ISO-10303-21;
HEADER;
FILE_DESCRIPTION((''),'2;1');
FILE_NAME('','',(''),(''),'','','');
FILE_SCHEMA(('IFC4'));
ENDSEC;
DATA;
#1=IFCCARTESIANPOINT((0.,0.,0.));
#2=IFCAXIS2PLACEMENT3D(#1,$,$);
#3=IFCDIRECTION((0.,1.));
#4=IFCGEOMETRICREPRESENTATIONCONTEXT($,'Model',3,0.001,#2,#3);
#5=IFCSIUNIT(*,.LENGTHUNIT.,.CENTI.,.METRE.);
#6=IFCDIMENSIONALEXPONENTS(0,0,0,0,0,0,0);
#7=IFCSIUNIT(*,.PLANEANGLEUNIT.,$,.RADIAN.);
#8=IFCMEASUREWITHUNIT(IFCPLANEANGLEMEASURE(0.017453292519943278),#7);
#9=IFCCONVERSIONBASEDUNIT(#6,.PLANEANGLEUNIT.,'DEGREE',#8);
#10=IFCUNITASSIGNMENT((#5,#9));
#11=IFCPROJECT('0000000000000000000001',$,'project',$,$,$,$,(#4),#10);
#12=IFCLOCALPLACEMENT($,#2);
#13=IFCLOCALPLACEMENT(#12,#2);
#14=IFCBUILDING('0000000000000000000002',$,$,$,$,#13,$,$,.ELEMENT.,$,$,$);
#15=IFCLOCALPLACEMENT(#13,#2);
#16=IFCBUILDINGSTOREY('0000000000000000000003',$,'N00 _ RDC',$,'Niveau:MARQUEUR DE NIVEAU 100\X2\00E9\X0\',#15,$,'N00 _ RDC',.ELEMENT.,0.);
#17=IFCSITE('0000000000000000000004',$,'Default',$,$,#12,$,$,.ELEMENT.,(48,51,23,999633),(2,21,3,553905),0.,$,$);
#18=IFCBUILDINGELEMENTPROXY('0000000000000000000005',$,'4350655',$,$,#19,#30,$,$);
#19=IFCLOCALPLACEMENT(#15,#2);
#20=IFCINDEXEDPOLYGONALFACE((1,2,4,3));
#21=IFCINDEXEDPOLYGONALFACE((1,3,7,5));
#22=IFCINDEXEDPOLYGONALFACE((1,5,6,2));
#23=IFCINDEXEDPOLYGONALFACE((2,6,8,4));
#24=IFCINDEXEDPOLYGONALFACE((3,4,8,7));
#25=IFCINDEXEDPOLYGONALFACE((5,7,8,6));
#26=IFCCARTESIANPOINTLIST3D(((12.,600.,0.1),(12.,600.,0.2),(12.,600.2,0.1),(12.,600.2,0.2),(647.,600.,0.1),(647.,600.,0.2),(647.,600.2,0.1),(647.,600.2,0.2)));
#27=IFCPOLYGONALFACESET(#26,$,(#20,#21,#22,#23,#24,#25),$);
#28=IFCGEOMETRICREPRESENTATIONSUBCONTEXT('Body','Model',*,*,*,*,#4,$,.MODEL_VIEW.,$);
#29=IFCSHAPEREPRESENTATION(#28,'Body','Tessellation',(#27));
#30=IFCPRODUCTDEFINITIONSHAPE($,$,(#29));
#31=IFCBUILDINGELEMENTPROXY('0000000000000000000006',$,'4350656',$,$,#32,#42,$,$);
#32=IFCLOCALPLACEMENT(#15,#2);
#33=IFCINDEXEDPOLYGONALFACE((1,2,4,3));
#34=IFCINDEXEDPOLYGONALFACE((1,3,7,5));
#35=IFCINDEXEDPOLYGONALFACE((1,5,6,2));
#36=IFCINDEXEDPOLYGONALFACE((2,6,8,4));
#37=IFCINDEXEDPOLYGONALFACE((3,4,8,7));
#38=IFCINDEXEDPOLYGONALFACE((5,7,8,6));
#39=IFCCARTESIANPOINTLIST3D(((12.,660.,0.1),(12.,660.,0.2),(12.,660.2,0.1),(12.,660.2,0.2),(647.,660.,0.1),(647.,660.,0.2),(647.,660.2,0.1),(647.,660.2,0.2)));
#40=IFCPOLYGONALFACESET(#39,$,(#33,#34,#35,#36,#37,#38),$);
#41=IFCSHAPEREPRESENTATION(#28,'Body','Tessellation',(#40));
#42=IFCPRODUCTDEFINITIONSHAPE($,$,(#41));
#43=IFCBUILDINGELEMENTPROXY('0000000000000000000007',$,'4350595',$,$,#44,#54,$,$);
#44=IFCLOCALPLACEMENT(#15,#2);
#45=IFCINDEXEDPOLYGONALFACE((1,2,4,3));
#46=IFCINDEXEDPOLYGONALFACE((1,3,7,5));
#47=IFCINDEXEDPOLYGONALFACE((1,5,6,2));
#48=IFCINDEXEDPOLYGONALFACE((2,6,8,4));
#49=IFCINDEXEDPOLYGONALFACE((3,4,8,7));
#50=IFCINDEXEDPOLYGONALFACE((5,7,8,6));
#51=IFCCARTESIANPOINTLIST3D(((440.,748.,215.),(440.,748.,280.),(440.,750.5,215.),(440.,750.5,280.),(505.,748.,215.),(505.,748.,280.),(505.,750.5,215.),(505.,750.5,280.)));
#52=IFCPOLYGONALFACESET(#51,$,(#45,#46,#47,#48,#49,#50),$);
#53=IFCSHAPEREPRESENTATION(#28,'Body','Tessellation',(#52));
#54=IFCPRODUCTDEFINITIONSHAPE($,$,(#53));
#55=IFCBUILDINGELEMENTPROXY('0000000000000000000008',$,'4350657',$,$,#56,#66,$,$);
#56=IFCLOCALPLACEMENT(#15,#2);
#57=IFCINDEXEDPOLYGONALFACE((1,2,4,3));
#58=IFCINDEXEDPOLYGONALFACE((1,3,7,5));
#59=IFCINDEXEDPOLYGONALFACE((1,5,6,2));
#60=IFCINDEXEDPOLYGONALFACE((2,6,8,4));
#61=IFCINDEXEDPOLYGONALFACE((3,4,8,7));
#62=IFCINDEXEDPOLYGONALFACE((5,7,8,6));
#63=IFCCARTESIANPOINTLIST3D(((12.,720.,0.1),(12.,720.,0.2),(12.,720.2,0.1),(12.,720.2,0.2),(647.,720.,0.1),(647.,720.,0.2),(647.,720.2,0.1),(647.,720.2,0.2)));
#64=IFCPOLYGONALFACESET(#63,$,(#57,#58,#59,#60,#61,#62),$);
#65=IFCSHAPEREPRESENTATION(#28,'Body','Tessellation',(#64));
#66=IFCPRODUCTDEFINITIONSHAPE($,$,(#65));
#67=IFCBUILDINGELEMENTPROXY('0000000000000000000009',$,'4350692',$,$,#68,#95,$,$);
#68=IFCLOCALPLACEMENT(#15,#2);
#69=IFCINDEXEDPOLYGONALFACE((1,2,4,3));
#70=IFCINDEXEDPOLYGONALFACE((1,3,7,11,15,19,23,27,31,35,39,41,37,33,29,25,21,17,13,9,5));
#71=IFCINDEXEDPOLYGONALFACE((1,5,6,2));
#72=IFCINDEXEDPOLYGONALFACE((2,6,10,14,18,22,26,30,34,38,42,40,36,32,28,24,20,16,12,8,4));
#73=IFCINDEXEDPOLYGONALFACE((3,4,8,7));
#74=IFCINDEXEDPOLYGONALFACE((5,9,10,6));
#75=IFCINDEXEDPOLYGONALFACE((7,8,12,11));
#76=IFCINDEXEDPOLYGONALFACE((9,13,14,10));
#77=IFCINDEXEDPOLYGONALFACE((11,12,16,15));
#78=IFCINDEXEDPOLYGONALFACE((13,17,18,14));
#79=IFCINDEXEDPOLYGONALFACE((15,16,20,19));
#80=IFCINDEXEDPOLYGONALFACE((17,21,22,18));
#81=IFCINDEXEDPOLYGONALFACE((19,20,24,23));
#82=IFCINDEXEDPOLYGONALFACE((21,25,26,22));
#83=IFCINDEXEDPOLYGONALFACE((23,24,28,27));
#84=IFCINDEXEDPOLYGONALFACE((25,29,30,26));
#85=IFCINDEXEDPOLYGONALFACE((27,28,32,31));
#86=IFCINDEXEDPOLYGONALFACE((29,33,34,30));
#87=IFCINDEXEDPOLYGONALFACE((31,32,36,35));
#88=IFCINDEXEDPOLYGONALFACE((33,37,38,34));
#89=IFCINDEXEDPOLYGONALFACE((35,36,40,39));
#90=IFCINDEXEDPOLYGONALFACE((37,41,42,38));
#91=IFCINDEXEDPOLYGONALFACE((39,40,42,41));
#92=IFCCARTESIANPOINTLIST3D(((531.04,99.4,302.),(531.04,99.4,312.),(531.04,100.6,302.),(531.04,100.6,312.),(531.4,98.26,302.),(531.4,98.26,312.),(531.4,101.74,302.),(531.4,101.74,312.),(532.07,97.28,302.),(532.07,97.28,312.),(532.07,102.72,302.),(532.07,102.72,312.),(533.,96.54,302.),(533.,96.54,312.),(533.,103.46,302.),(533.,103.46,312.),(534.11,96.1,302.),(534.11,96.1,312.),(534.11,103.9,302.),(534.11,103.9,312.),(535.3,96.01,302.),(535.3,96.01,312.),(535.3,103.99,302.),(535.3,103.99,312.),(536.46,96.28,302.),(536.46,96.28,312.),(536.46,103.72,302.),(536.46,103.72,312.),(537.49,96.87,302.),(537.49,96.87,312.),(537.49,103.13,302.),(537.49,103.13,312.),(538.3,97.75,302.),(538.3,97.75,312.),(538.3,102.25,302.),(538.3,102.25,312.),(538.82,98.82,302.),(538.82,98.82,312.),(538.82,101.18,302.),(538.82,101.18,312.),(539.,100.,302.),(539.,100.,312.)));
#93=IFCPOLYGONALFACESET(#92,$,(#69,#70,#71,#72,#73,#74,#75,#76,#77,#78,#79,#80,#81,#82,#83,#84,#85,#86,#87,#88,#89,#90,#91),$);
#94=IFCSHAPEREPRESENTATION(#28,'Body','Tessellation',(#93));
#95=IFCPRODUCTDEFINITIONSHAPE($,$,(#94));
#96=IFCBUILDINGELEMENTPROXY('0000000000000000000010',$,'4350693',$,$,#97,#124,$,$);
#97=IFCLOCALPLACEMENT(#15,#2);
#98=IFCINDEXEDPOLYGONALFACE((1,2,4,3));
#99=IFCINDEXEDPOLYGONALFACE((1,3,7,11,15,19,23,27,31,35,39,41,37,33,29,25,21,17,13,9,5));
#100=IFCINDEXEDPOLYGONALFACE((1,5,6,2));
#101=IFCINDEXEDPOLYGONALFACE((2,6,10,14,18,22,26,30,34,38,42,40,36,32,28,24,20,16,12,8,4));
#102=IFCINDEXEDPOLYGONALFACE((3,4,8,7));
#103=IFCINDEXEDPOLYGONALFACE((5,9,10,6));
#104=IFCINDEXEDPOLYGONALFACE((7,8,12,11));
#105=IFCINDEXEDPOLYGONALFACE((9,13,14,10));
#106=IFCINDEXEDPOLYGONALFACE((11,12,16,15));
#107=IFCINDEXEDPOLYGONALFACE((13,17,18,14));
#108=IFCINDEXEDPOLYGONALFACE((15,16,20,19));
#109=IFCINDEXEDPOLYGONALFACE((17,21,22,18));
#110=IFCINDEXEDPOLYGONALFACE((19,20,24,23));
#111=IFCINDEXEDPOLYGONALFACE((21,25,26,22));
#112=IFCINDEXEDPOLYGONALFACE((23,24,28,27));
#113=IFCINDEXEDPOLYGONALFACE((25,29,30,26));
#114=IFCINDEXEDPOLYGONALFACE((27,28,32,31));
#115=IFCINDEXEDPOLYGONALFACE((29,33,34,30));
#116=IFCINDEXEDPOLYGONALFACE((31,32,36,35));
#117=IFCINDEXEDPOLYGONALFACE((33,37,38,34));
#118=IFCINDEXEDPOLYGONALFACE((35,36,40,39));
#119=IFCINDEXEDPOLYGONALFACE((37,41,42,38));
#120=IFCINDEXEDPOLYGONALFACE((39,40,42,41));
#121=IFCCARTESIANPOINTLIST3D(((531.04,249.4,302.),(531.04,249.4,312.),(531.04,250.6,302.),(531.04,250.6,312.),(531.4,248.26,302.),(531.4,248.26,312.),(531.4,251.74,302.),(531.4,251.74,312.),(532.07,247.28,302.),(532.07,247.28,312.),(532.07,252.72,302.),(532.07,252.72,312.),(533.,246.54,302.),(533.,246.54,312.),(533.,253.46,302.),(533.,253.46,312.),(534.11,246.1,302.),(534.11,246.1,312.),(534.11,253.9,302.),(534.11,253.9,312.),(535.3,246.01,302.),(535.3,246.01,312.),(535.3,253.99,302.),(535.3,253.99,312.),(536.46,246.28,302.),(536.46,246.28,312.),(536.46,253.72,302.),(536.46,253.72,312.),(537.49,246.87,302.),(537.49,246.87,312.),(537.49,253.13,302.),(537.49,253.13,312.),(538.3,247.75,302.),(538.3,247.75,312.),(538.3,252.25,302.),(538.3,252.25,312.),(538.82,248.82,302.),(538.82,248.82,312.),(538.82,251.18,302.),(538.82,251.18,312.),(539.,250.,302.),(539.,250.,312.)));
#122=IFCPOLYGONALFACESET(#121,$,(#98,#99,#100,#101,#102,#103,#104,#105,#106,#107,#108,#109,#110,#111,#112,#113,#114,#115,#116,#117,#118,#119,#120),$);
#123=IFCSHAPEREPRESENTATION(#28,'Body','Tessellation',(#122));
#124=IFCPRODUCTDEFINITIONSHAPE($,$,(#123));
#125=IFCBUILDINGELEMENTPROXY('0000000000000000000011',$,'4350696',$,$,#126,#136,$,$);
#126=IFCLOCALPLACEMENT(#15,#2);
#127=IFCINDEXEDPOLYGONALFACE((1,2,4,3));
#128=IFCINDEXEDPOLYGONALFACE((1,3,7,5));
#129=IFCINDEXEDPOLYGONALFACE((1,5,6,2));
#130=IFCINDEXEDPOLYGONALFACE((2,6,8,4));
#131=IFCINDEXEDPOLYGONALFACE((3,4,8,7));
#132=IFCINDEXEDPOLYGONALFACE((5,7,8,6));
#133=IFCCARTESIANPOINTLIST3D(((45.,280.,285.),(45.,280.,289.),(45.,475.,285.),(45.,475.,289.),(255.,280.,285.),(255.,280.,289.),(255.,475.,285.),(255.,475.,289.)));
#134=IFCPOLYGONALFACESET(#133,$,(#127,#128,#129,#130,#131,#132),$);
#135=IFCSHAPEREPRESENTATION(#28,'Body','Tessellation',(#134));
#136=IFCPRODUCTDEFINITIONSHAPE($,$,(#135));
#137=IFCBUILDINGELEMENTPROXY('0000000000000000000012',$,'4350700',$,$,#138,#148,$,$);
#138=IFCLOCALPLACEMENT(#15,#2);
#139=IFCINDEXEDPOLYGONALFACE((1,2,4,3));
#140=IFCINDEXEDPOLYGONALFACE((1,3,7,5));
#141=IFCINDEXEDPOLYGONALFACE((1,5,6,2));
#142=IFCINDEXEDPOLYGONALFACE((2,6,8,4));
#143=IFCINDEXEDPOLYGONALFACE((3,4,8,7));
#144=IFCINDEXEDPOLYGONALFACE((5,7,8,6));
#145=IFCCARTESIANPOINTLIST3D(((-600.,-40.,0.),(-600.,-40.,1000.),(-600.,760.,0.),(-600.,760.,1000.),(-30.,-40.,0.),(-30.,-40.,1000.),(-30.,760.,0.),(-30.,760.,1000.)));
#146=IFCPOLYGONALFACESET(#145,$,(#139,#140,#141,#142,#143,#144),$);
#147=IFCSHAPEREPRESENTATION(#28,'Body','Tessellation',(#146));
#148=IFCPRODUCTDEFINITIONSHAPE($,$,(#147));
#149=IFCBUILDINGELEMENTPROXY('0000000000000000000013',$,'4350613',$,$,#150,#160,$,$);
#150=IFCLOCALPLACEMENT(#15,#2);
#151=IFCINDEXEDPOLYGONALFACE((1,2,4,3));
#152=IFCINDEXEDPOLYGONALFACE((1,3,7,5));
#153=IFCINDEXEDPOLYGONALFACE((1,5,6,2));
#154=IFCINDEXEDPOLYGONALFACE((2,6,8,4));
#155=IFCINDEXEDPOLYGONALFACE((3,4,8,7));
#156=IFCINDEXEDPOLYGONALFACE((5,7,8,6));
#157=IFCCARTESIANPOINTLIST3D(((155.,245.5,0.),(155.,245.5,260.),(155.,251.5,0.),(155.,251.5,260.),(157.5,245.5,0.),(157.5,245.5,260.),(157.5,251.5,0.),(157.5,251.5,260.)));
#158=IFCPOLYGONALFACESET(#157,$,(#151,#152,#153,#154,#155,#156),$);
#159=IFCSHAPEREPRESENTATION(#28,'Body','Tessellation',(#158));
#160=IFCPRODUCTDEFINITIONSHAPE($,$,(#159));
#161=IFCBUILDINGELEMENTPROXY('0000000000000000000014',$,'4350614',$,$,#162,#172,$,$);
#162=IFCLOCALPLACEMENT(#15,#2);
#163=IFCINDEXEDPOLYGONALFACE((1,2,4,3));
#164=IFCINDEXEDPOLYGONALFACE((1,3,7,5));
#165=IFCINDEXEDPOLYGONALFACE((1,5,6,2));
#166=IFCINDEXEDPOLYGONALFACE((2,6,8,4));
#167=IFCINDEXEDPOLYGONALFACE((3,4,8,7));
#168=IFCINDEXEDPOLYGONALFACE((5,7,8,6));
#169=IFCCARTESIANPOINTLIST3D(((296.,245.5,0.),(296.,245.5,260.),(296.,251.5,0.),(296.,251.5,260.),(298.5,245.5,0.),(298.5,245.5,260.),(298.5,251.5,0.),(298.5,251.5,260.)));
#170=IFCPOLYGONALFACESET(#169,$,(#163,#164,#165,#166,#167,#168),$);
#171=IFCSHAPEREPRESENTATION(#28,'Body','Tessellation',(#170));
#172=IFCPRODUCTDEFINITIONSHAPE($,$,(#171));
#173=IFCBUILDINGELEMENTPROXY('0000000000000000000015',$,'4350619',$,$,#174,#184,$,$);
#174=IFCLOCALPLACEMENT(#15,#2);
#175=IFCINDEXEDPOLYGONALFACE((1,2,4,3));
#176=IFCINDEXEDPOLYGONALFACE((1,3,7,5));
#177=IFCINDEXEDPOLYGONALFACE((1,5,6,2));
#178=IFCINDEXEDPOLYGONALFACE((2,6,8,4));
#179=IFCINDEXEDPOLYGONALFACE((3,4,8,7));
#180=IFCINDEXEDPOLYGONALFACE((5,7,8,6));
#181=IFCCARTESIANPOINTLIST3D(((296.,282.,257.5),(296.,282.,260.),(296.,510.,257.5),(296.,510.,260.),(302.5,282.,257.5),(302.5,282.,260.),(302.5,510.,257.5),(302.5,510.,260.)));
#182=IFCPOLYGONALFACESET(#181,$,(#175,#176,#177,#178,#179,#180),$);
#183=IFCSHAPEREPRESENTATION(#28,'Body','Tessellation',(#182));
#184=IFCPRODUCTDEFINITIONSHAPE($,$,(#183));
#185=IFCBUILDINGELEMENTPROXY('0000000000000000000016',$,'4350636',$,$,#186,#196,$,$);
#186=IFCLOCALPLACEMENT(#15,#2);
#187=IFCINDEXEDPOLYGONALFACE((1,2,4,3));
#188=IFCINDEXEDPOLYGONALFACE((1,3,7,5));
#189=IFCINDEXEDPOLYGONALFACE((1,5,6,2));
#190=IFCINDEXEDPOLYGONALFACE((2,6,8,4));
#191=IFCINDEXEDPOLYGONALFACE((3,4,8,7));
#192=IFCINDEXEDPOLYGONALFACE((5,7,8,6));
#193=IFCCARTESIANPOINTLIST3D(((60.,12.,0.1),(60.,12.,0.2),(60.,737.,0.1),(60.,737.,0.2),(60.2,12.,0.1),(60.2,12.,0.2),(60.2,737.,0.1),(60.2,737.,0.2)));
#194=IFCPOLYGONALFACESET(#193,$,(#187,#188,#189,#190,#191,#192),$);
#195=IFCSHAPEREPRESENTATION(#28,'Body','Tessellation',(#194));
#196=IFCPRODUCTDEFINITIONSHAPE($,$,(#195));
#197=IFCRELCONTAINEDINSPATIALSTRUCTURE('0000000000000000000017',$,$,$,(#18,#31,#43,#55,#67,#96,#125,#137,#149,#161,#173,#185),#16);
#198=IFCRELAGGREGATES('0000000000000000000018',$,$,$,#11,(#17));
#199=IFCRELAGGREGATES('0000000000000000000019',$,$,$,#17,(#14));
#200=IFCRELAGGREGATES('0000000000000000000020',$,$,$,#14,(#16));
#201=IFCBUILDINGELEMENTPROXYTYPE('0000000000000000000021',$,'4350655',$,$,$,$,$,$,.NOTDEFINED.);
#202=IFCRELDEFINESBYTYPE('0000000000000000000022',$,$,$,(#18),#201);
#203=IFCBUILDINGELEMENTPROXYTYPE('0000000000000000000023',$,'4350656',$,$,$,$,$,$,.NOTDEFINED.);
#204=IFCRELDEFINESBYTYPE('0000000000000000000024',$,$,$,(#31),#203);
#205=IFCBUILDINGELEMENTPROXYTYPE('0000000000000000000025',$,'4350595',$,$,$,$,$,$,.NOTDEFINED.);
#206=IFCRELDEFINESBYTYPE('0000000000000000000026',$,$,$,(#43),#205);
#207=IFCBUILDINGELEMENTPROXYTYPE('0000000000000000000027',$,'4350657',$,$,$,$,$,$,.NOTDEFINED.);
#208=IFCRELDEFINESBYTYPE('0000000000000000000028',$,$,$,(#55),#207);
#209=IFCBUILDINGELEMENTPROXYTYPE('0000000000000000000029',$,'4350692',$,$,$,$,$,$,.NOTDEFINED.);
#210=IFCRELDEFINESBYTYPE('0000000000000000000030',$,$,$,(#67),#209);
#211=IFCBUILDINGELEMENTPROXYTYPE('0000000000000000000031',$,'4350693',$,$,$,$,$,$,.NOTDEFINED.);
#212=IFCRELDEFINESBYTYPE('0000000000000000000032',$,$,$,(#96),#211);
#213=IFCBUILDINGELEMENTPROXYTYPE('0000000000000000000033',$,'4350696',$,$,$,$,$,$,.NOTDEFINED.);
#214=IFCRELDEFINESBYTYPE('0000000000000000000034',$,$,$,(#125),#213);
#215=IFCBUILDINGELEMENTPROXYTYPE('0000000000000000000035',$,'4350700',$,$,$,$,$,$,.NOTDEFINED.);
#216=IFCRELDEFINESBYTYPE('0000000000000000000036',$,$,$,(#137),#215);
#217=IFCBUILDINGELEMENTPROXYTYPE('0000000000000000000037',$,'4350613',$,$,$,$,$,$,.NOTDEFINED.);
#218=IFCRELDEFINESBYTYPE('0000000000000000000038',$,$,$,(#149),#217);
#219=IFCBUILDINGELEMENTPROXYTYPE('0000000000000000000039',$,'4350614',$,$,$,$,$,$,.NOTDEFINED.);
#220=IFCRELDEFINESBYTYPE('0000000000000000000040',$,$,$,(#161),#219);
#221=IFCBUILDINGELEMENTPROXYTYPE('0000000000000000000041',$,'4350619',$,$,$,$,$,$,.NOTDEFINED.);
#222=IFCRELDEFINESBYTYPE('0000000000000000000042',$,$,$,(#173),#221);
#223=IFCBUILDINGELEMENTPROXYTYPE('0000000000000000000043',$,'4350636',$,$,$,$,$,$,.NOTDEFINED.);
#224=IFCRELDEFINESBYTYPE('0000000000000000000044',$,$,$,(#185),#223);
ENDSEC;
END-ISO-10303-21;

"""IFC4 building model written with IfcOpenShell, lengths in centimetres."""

from ifc_helpers import new_model, entity, si_unit, converted_unit, direction, frame, frame_2d, origin, origin_2d_with_axis, place, context, subcontext, project, spatial, rectangle, circle, extrude, type_object, element, save


model = new_model("IFC4")

# Units and contexts
model_context = context("Model", 3, precision=0.001, world=origin(), true_north=direction((0.0, 1.0)))
body_context = subcontext(model_context, "Body", "Model", "MODEL_VIEW")
ifc_project = project(units=[si_unit("LENGTHUNIT", "METRE", prefix="CENTI"), converted_unit("PLANEANGLEUNIT", "DEGREE", entity("IfcPlaneAngleMeasure", 0.017453292519943278), si_unit("PLANEANGLEUNIT", "RADIAN"), dimensions=[0, 0, 0, 0, 0, 0, 0])], contexts=[model_context])

# Site, building, storey
site_placement = place(None, origin())
site = spatial("IfcSite", under=ifc_project, at=site_placement, Name="Default", CompositionType="ELEMENT", RefLatitude=(48, 51, 23, 999633), RefLongitude=(2, 21, 3, 553905), RefElevation=0.0)
building_placement = place(site_placement, origin())
building = spatial("IfcBuilding", under=site, at=building_placement, CompositionType="ELEMENT")
storey_placement = place(building_placement, origin())
storey = spatial("IfcBuildingStorey", under=building, at=storey_placement, Name="N00 _ RDC", ObjectType="Niveau:MARQUEUR DE NIVEAU 100é", LongName="N00 _ RDC", CompositionType="ELEMENT", Elevation=0.0)

# Building element proxies
building_element_proxy_type_1 = type_object("IfcBuildingElementProxyType", Name="4350655", PredefinedType="NOTDEFINED")
proxy_1_placement = place(storey_placement, origin())
element("IfcBuildingElementProxy", 1, at=proxy_1_placement, inside=storey, type_object=building_element_proxy_type_1, Name="4350655", context=body_context, shape_type="SweptSolid", body=[
    extrude(rectangle(XDim=635.0, YDim=0.2, at=frame_2d((0.0, 0.0), x_axis=(1.0, 0.0))), frame((329.5, 600.1, 0.1)), (0.0, 0.0, 1.0), 0.1),
])
building_element_proxy_type_2 = type_object("IfcBuildingElementProxyType", Name="4350656", PredefinedType="NOTDEFINED")
proxy_2_placement = place(storey_placement, origin())
element("IfcBuildingElementProxy", 2, at=proxy_2_placement, inside=storey, type_object=building_element_proxy_type_2, Name="4350656", context=body_context, shape_type="SweptSolid", body=[
    extrude(rectangle(XDim=635.0, YDim=0.2, at=frame_2d((0.0, 0.0), x_axis=(1.0, 0.0))), frame((329.5, 660.1, 0.1)), (0.0, 0.0, 1.0), 0.1),
])
building_element_proxy_type_3 = type_object("IfcBuildingElementProxyType", Name="4350595", PredefinedType="NOTDEFINED")
proxy_3_placement = place(storey_placement, origin())
element("IfcBuildingElementProxy", 3, at=proxy_3_placement, inside=storey, type_object=building_element_proxy_type_3, Name="4350595", context=body_context, shape_type="SweptSolid", body=[
    extrude(rectangle(XDim=65.0, YDim=2.5, at=frame_2d((0.0, 0.0), x_axis=(1.0, 0.0))), frame((472.5, 749.25, 215.0)), (0.0, 0.0, 1.0), 65.0),
])
building_element_proxy_type_4 = type_object("IfcBuildingElementProxyType", Name="4350657", PredefinedType="NOTDEFINED")
proxy_4_placement = place(storey_placement, origin())
element("IfcBuildingElementProxy", 4, at=proxy_4_placement, inside=storey, type_object=building_element_proxy_type_4, Name="4350657", context=body_context, shape_type="SweptSolid", body=[
    extrude(rectangle(XDim=635.0, YDim=0.2, at=frame_2d((0.0, 0.0), x_axis=(1.0, 0.0))), frame((329.5, 720.1, 0.1)), (0.0, 0.0, 1.0), 0.1),
])
building_element_proxy_type_5 = type_object("IfcBuildingElementProxyType", Name="4350692", PredefinedType="NOTDEFINED")
proxy_5_placement = place(storey_placement, origin())
element("IfcBuildingElementProxy", 5, at=proxy_5_placement, inside=storey, type_object=building_element_proxy_type_5, Name="4350692", context=body_context, shape_type="SweptSolid", body=[
    extrude(circle(Radius=4.0, at=origin_2d_with_axis()), frame((535.0, 100.0, 302.0)), (0.0, 0.0, 1.0), 10.0),
])
building_element_proxy_type_6 = type_object("IfcBuildingElementProxyType", Name="4350693", PredefinedType="NOTDEFINED")
proxy_6_placement = place(storey_placement, origin())
element("IfcBuildingElementProxy", 6, at=proxy_6_placement, inside=storey, type_object=building_element_proxy_type_6, Name="4350693", context=body_context, shape_type="SweptSolid", body=[
    extrude(circle(Radius=4.0, at=origin_2d_with_axis()), frame((535.0, 250.0, 302.0)), (0.0, 0.0, 1.0), 10.0),
])
building_element_proxy_type_7 = type_object("IfcBuildingElementProxyType", Name="4350696", PredefinedType="NOTDEFINED")
proxy_7_placement = place(storey_placement, origin())
element("IfcBuildingElementProxy", 7, at=proxy_7_placement, inside=storey, type_object=building_element_proxy_type_7, Name="4350696", context=body_context, shape_type="SweptSolid", body=[
    extrude(rectangle(XDim=210.0, YDim=195.0, at=frame_2d((0.0, 0.0), x_axis=(1.0, 0.0))), frame((150.0, 377.5, 285.0)), (0.0, 0.0, 1.0), 4.0),
])
building_element_proxy_type_8 = type_object("IfcBuildingElementProxyType", Name="4350700", PredefinedType="NOTDEFINED")
proxy_8_placement = place(storey_placement, origin())
element("IfcBuildingElementProxy", 8, at=proxy_8_placement, inside=storey, type_object=building_element_proxy_type_8, Name="4350700", context=body_context, shape_type="SweptSolid", body=[
    extrude(rectangle(XDim=570.0, YDim=800.0, at=origin_2d_with_axis()), frame((-315.0, 360.0, 0.0)), (0.0, 0.0, 1.0), 1000.0),
])
building_element_proxy_type_9 = type_object("IfcBuildingElementProxyType", Name="4350613", PredefinedType="NOTDEFINED")
proxy_9_placement = place(storey_placement, origin())
element("IfcBuildingElementProxy", 9, at=proxy_9_placement, inside=storey, type_object=building_element_proxy_type_9, Name="4350613", context=body_context, shape_type="SweptSolid", body=[
    extrude(rectangle(XDim=2.5, YDim=6.0, at=frame_2d((0.0, 0.0), x_axis=(1.0, 0.0))), frame((156.25, 248.5, 0.0)), (0.0, 0.0, 1.0), 260.0),
])
building_element_proxy_type_10 = type_object("IfcBuildingElementProxyType", Name="4350614", PredefinedType="NOTDEFINED")
proxy_10_placement = place(storey_placement, origin())
element("IfcBuildingElementProxy", 10, at=proxy_10_placement, inside=storey, type_object=building_element_proxy_type_10, Name="4350614", context=body_context, shape_type="SweptSolid", body=[
    extrude(rectangle(XDim=2.5, YDim=6.0, at=frame_2d((0.0, 0.0), x_axis=(1.0, 0.0))), frame((297.25, 248.5, 0.0)), (0.0, 0.0, 1.0), 260.0),
])
building_element_proxy_type_11 = type_object("IfcBuildingElementProxyType", Name="4350619", PredefinedType="NOTDEFINED")
proxy_11_placement = place(storey_placement, origin())
element("IfcBuildingElementProxy", 11, at=proxy_11_placement, inside=storey, type_object=building_element_proxy_type_11, Name="4350619", context=body_context, shape_type="SweptSolid", body=[
    extrude(rectangle(XDim=6.5, YDim=228.0, at=frame_2d((0.0, 0.0), x_axis=(1.0, 0.0))), frame((299.25, 396.0, 257.5)), (0.0, 0.0, 1.0), 2.5),
])
building_element_proxy_type_12 = type_object("IfcBuildingElementProxyType", Name="4350636", PredefinedType="NOTDEFINED")
proxy_12_placement = place(storey_placement, origin())
element("IfcBuildingElementProxy", 12, at=proxy_12_placement, inside=storey, type_object=building_element_proxy_type_12, Name="4350636", context=body_context, shape_type="SweptSolid", body=[
    extrude(rectangle(XDim=0.2, YDim=725.0, at=frame_2d((0.0, 0.0), x_axis=(1.0, 0.0))), frame((60.1, 374.5, 0.1)), (0.0, 0.0, 1.0), 0.1),
])

save(model, "model.ifc")
